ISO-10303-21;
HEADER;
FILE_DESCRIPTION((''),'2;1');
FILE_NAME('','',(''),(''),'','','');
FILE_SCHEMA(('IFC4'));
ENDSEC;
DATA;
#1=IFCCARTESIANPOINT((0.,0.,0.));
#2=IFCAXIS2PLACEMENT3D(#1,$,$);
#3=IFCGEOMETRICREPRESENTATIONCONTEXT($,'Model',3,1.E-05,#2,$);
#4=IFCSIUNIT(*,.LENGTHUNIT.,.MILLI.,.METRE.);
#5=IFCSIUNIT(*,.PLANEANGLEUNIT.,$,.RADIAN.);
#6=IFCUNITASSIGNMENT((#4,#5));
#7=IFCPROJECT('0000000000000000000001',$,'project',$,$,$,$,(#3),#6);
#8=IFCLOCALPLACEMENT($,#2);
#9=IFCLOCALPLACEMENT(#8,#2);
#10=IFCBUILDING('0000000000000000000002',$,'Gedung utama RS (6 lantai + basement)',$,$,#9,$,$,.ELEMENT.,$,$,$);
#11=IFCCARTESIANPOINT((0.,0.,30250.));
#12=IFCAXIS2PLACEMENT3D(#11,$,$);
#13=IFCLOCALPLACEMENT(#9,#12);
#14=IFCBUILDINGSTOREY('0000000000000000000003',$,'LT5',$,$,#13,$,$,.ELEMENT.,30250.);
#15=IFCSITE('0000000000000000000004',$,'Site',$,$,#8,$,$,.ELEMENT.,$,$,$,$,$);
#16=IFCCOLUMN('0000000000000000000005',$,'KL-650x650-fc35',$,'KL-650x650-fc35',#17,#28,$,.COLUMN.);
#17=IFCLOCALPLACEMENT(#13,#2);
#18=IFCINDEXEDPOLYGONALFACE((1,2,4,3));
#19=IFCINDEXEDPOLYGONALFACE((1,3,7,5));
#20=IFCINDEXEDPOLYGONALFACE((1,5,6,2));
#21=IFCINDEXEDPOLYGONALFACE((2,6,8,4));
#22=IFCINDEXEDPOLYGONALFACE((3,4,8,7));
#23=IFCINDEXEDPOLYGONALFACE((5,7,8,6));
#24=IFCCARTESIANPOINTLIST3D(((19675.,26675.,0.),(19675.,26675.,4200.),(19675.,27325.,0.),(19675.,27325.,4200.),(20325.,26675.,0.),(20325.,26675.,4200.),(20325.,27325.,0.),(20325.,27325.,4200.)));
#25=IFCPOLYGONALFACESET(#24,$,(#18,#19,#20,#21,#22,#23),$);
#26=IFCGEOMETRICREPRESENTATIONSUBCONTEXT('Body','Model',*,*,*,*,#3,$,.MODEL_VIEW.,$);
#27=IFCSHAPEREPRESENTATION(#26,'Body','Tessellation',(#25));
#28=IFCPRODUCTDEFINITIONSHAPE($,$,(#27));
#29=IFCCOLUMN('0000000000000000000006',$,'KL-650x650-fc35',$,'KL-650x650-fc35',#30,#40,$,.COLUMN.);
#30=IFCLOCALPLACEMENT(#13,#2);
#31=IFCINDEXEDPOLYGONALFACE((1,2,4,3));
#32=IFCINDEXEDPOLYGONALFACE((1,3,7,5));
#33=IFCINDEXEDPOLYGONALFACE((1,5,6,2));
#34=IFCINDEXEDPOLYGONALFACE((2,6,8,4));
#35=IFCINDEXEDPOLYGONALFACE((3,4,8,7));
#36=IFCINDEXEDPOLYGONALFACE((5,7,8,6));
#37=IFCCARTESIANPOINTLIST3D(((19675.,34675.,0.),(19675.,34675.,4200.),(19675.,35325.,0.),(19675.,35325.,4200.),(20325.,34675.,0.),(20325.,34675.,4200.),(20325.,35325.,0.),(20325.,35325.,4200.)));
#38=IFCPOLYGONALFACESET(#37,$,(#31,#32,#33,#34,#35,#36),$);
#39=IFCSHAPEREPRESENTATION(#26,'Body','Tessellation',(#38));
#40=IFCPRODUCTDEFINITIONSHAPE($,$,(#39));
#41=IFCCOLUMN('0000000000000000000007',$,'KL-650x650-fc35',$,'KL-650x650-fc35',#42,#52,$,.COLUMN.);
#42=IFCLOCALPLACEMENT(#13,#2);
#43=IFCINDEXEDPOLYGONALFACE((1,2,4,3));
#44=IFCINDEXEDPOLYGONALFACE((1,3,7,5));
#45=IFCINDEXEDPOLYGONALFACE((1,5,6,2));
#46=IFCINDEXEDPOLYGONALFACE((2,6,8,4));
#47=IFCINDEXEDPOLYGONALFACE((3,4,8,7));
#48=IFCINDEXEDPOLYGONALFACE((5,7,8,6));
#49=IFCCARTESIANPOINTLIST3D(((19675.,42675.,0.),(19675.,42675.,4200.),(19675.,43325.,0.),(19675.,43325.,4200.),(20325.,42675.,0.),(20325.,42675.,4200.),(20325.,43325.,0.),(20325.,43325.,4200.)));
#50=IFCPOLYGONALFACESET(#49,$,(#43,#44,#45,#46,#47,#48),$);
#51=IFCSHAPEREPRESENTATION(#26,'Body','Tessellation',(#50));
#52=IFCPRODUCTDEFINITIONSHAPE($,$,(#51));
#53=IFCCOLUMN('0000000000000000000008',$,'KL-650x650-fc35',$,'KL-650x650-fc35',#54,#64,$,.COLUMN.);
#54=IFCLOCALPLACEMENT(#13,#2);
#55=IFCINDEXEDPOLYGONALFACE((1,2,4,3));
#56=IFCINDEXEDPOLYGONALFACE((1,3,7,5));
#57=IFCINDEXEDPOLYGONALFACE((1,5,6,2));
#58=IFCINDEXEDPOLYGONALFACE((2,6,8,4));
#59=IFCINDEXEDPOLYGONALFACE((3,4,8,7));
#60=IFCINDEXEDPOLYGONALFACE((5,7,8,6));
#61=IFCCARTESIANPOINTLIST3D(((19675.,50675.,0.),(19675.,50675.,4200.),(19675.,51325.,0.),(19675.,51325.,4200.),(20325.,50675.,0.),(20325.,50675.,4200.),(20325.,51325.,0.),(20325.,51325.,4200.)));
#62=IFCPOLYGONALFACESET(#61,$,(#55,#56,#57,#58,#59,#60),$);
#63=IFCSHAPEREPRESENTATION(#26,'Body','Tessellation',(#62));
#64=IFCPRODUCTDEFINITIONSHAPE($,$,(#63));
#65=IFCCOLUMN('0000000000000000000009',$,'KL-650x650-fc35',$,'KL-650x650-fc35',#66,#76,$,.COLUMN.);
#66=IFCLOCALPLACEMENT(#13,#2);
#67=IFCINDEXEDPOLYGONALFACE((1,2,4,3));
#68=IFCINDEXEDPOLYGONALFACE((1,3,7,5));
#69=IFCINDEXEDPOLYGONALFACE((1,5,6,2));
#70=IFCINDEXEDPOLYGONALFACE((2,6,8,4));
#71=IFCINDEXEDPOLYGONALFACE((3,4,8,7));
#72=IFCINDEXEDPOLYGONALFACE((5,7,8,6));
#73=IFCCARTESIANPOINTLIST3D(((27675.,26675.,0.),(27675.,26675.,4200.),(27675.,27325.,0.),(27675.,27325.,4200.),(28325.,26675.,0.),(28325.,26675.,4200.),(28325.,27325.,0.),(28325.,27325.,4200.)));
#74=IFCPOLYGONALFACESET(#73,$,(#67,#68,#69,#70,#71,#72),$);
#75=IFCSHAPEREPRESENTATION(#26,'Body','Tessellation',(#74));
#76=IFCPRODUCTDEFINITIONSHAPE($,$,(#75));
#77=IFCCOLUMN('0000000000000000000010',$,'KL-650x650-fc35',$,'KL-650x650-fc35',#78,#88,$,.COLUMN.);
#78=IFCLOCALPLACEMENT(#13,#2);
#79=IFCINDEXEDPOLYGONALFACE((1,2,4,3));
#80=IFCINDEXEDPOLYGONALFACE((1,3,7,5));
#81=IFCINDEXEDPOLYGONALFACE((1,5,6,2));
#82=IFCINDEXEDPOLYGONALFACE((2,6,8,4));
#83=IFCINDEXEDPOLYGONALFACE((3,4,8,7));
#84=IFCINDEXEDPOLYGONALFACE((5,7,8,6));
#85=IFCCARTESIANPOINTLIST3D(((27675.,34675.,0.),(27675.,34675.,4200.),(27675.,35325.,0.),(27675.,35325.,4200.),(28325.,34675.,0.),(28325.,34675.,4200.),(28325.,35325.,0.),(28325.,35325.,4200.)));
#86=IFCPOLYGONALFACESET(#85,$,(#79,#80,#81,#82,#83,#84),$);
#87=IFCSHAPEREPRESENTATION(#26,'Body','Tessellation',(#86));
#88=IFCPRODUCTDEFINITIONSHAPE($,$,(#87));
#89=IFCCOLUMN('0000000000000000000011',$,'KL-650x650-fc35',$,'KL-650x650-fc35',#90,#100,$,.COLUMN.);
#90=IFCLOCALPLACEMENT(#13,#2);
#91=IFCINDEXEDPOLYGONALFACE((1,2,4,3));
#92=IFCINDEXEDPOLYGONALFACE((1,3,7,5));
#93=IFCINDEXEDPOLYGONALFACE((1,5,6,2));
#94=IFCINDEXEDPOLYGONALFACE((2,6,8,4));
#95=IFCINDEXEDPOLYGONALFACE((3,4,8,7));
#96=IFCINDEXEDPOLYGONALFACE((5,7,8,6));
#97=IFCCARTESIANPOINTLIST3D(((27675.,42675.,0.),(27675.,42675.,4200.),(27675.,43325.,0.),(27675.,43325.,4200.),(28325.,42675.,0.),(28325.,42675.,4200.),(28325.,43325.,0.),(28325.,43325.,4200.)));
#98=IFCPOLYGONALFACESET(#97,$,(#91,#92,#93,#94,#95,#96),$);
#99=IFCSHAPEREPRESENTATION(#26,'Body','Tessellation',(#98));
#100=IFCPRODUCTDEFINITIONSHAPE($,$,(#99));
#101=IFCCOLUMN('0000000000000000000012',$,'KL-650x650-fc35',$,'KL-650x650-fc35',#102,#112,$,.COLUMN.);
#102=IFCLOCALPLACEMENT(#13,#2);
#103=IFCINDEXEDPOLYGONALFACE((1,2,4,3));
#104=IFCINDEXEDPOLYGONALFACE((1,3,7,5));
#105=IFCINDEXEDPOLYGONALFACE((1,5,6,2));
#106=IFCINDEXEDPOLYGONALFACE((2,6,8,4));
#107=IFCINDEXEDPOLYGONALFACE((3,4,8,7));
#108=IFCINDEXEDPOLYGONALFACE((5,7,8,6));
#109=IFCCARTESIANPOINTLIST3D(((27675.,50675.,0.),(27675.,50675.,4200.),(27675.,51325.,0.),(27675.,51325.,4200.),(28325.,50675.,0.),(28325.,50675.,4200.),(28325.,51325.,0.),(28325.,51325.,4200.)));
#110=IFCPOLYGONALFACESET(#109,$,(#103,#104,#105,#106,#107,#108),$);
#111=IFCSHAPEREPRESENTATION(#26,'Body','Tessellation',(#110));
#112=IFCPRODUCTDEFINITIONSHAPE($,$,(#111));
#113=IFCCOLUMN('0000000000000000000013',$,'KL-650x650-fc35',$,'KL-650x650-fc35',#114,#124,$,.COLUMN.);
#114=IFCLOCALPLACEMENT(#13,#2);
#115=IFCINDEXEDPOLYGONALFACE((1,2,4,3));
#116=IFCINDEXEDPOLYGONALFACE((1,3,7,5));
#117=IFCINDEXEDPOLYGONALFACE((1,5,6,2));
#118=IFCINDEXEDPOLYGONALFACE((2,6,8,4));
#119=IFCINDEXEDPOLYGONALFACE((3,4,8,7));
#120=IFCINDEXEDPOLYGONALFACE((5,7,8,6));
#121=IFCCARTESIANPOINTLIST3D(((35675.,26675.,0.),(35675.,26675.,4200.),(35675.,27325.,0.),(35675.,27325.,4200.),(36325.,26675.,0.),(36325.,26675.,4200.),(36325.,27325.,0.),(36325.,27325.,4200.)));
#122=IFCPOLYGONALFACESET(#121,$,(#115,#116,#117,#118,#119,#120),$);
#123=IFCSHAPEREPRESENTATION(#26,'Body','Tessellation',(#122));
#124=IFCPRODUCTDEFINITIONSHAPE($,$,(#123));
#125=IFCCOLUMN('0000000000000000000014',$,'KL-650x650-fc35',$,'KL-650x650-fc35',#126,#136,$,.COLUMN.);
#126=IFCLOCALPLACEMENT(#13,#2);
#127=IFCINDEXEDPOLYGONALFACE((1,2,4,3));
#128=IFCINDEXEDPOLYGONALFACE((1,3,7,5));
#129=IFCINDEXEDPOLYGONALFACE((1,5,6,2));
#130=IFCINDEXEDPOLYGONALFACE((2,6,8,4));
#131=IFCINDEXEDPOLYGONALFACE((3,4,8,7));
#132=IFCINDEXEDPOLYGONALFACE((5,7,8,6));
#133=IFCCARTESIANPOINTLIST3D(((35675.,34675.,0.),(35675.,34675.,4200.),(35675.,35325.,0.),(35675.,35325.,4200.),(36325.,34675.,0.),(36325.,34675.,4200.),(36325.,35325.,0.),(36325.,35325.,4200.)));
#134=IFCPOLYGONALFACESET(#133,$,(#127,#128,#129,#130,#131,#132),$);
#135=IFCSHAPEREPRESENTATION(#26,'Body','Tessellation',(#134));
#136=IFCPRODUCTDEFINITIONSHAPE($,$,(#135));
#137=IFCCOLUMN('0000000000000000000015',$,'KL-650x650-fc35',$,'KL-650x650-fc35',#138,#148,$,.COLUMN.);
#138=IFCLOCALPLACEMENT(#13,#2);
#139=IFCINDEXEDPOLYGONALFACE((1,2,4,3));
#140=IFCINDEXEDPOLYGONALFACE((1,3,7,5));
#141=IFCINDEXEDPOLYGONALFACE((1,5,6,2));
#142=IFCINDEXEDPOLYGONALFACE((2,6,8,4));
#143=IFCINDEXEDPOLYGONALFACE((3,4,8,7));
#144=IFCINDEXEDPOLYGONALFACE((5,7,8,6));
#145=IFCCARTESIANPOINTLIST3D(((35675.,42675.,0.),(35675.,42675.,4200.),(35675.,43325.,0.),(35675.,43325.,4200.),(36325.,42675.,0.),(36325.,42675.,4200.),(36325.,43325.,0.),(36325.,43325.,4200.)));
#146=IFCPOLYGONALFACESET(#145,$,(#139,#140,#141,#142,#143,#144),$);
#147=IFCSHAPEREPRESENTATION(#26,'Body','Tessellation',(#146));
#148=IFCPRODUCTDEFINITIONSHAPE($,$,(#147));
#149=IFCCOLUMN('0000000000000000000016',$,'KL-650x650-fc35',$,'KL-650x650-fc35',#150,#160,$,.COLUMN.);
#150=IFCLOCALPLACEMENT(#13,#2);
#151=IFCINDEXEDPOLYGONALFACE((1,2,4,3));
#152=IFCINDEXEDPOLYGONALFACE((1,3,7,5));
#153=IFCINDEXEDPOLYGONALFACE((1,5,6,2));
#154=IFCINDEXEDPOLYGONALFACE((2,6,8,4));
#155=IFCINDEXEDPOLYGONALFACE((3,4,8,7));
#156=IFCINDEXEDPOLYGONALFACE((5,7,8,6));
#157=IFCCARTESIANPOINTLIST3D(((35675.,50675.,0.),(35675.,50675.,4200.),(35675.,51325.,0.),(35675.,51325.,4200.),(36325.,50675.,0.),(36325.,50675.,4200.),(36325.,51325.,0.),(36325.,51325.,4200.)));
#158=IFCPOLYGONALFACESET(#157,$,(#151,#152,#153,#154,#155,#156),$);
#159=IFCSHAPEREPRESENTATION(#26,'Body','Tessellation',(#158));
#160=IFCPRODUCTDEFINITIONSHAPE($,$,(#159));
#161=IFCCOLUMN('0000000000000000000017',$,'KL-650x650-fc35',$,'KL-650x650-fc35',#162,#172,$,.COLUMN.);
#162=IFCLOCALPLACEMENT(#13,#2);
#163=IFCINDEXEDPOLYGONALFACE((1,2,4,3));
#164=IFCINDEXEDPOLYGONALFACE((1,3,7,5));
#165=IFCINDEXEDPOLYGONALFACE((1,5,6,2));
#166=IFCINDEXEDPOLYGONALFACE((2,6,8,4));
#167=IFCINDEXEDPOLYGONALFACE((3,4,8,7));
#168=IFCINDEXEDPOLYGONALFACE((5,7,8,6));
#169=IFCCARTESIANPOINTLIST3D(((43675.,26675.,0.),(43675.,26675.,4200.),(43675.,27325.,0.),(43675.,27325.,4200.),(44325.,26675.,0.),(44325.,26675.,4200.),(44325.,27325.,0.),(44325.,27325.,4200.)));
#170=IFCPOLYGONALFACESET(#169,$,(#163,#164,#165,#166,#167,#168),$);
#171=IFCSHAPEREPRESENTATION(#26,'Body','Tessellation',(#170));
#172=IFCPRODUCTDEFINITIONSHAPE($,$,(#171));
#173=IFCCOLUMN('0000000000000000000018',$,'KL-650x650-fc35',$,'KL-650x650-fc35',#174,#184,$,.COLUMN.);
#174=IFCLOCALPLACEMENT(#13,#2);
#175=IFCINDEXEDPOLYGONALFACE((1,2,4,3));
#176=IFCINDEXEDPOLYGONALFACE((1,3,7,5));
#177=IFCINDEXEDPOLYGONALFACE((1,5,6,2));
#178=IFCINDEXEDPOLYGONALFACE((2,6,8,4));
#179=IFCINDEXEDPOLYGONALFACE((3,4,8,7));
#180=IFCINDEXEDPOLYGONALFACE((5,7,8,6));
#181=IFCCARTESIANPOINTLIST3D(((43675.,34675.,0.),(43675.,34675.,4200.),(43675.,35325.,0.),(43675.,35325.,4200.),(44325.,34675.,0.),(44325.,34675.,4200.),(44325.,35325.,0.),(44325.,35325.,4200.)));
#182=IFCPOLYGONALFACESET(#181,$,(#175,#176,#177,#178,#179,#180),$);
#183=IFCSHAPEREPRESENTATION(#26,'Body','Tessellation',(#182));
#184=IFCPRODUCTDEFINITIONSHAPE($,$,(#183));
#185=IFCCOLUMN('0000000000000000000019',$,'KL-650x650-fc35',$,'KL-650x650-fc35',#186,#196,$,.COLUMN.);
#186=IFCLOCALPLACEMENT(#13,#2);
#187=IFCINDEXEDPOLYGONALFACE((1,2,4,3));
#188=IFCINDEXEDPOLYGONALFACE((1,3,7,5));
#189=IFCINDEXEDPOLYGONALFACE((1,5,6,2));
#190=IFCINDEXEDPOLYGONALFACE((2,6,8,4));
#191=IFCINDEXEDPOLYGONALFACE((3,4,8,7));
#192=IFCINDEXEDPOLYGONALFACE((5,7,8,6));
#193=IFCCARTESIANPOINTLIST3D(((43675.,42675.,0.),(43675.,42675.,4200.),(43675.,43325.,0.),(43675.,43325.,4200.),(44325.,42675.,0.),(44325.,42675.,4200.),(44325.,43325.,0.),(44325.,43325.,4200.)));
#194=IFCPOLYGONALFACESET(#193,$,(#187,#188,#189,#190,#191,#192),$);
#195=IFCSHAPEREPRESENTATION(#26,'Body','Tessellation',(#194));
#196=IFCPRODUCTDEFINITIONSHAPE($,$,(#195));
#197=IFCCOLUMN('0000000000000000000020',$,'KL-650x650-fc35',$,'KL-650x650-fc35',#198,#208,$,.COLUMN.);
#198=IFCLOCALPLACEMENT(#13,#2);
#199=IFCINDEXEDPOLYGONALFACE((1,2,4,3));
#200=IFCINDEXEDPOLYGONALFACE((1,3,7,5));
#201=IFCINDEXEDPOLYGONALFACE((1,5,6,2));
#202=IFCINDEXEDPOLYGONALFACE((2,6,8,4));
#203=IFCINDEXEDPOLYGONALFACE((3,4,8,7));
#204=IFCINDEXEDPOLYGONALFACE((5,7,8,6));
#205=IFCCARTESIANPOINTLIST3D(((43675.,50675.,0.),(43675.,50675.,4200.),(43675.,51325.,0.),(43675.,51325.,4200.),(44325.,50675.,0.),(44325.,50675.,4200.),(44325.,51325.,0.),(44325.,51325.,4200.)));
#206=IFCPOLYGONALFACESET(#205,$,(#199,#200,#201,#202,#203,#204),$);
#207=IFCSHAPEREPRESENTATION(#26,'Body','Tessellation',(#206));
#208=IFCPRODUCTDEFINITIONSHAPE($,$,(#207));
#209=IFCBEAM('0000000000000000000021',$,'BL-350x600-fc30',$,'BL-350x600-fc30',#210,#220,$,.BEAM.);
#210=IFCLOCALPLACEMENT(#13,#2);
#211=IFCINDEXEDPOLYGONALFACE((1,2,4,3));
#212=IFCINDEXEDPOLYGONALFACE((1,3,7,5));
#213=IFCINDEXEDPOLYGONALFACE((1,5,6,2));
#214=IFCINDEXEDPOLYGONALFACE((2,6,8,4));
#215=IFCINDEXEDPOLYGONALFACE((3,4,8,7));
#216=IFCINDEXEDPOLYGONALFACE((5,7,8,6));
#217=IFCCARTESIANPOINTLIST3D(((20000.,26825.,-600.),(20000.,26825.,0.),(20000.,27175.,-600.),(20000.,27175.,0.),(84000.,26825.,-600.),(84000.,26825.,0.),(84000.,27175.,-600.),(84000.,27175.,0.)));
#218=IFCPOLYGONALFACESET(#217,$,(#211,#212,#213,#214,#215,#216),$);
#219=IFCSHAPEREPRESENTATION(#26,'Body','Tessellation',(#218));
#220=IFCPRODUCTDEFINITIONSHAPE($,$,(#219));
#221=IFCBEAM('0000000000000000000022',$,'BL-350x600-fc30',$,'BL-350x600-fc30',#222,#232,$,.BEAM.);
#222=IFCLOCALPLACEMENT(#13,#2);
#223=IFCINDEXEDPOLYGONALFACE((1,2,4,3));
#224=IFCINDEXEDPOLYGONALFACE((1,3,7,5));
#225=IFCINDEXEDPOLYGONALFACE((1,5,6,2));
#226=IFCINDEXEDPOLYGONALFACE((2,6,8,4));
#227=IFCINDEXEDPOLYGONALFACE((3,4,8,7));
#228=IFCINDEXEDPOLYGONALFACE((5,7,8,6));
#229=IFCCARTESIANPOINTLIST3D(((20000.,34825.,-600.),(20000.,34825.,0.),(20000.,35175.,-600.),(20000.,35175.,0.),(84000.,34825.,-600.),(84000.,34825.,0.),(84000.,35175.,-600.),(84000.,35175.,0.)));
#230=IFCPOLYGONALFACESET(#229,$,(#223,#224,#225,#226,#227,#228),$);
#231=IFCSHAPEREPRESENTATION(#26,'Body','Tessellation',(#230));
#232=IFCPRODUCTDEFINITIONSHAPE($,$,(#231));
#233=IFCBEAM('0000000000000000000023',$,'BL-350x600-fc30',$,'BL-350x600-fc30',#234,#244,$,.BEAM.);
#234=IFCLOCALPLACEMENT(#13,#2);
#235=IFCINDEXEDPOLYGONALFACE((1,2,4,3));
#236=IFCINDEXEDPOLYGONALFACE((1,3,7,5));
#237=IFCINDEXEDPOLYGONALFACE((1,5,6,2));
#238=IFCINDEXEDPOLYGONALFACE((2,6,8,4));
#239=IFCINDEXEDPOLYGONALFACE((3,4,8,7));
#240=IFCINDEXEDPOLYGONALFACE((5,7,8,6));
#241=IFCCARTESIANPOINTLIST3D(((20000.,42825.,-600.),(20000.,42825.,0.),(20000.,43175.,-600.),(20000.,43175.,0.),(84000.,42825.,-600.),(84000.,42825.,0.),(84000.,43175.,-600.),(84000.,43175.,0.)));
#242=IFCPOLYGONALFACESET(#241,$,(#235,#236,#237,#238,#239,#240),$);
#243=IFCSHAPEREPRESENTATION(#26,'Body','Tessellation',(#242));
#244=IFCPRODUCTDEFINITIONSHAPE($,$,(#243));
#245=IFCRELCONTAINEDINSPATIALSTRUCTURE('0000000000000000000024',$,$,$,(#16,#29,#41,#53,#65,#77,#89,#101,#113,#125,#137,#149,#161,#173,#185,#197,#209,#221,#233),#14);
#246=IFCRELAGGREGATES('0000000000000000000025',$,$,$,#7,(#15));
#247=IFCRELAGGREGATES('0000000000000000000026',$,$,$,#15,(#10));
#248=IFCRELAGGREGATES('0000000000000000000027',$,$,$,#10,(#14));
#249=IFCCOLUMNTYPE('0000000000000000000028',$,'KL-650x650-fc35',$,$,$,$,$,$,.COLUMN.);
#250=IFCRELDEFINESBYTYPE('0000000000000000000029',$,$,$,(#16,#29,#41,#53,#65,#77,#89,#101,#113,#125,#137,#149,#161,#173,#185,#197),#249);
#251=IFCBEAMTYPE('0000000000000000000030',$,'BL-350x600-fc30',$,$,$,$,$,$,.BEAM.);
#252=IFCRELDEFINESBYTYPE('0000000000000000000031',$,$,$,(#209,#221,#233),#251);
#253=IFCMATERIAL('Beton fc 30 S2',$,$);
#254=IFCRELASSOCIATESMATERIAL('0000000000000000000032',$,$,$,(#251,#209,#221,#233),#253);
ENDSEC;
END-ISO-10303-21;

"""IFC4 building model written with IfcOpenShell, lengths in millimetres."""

from ifc_helpers import new_model, si_unit, frame, origin, origin_2d, place, context, subcontext, project, spatial, rectangle, extrude, material, material_profile, profile_set, profile_usage, type_object, element, save


model = new_model("IFC4")

# Units and contexts
model_context = context("Model", 3, precision=1e-05, world=origin())
body_context = subcontext(model_context, "Body", "Model", "MODEL_VIEW")
ifc_project = project(units=[si_unit("LENGTHUNIT", "METRE", prefix="MILLI"), si_unit("PLANEANGLEUNIT", "RADIAN")], contexts=[model_context])

# Site, building, storey
site_placement = place(None, origin())
site = spatial("IfcSite", under=ifc_project, at=site_placement, Name="Site", CompositionType="ELEMENT")
building_placement = place(site_placement, origin())
building = spatial("IfcBuilding", under=site, at=building_placement, Name="Gedung utama RS (6 lantai + basement)", CompositionType="ELEMENT")
storey_placement = place(building_placement, frame((0.0, 0.0, 30250.0)))
storey = spatial("IfcBuildingStorey", under=building, at=storey_placement, Name="LT5", CompositionType="ELEMENT", Elevation=30250.0)

# Columns
ifc_material_profile_1 = material_profile(None, rectangle(XDim=650.0, YDim=650.0, at=origin_2d()), Name="KL-650x650-fc35")
ifc_profile_set_1 = profile_set([ifc_material_profile_1], Name="KL-650x650-fc35")
ifc_profile_usage_1 = profile_usage(ifc_profile_set_1, cardinal=5)
column_type = type_object("IfcColumnType", Name="KL-650x650-fc35", PredefinedType="COLUMN", material=ifc_profile_set_1)
for number, where, z_axis, x_axis, name in (
    (1, (20000.0, 27000.0, 0.0), (0.0, 0.0, 1.0), (1.0, 0.0, 0.0), "KL-650x650-fc35"),
    (2, (20000.0, 35000.0, 0.0), (0.0, 0.0, 1.0), (1.0, 0.0, 0.0), "KL-650x650-fc35"),
    (3, (20000.0, 43000.0, 0.0), (0.0, 0.0, 1.0), (1.0, 0.0, 0.0), "KL-650x650-fc35"),
    (4, (20000.0, 51000.0, 0.0), (0.0, 0.0, 1.0), (1.0, 0.0, 0.0), "KL-650x650-fc35"),
    (5, (28000.0, 27000.0, 0.0), (0.0, 0.0, 1.0), (1.0, 0.0, 0.0), "KL-650x650-fc35"),
    (6, (28000.0, 35000.0, 0.0), (0.0, 0.0, 1.0), (1.0, 0.0, 0.0), "KL-650x650-fc35"),
    (7, (28000.0, 43000.0, 0.0), (0.0, 0.0, 1.0), (1.0, 0.0, 0.0), "KL-650x650-fc35"),
    (8, (28000.0, 51000.0, 0.0), (0.0, 0.0, 1.0), (1.0, 0.0, 0.0), "KL-650x650-fc35"),
    (9, (36000.0, 27000.0, 0.0), (0.0, 0.0, 1.0), (1.0, 0.0, 0.0), "KL-650x650-fc35"),
    (10, (36000.0, 35000.0, 0.0), (0.0, 0.0, 1.0), (1.0, 0.0, 0.0), "KL-650x650-fc35"),
    (11, (36000.0, 43000.0, 0.0), (0.0, 0.0, 1.0), (1.0, 0.0, 0.0), "KL-650x650-fc35"),
    (12, (36000.0, 51000.0, 0.0), (0.0, 0.0, 1.0), (1.0, 0.0, 0.0), "KL-650x650-fc35"),
    (13, (44000.0, 27000.0, 0.0), (0.0, 0.0, 1.0), (1.0, 0.0, 0.0), "KL-650x650-fc35"),
    (14, (44000.0, 35000.0, 0.0), (0.0, 0.0, 1.0), (1.0, 0.0, 0.0), "KL-650x650-fc35"),
    (15, (44000.0, 43000.0, 0.0), (0.0, 0.0, 1.0), (1.0, 0.0, 0.0), "KL-650x650-fc35"),
    (16, (44000.0, 51000.0, 0.0), (0.0, 0.0, 1.0), (1.0, 0.0, 0.0), "KL-650x650-fc35"),
):
    element("IfcColumn", number, at=place(storey_placement, frame(where, z_axis=z_axis, x_axis=x_axis)), inside=storey, type_object=column_type, material=ifc_profile_usage_1, Name=name, ObjectType="KL-650x650-fc35", PredefinedType="COLUMN", context=body_context, shape_type="SweptSolid", body=[
        extrude(rectangle(XDim=650.0, YDim=650.0, at=origin_2d()), origin(), (0.0, 0.0, 1.0), 4200.0),
    ])

# Beams
ifc_material = material(Name="Beton fc 30 S2")
ifc_material_profile_2 = material_profile(ifc_material, rectangle(XDim=350.0, YDim=600.0, at=origin_2d()), Name="BL-350x600-fc30")
ifc_profile_set_2 = profile_set([ifc_material_profile_2], Name="BL-350x600-fc30")
ifc_profile_usage_2 = profile_usage(ifc_profile_set_2, cardinal=8)
beam_type = type_object("IfcBeamType", Name="BL-350x600-fc30", PredefinedType="BEAM", material=ifc_profile_set_2)
for number, where, name in (
    (17, (20000.0, 27000.0, -300.0), "BL-350x600-fc30"),
    (18, (20000.0, 35000.0, -300.0), "BL-350x600-fc30"),
    (19, (20000.0, 43000.0, -300.0), "BL-350x600-fc30"),
):
    element("IfcBeam", number, at=place(storey_placement, frame(where)), inside=storey, type_object=beam_type, material=ifc_profile_usage_2, Name=name, ObjectType="BL-350x600-fc30", PredefinedType="BEAM", context=body_context, shape_type="SweptSolid", body=[
        extrude(rectangle(XDim=350.0, YDim=600.0, at=origin_2d()), frame((0.0, 0.0, 0.0), z_axis=(1.0, 0.0, 0.0), x_axis=(0.0, 1.0, 0.0)), (0.0, 0.0, 1.0), 64000.0),
    ])

save(model, "model.ifc")
